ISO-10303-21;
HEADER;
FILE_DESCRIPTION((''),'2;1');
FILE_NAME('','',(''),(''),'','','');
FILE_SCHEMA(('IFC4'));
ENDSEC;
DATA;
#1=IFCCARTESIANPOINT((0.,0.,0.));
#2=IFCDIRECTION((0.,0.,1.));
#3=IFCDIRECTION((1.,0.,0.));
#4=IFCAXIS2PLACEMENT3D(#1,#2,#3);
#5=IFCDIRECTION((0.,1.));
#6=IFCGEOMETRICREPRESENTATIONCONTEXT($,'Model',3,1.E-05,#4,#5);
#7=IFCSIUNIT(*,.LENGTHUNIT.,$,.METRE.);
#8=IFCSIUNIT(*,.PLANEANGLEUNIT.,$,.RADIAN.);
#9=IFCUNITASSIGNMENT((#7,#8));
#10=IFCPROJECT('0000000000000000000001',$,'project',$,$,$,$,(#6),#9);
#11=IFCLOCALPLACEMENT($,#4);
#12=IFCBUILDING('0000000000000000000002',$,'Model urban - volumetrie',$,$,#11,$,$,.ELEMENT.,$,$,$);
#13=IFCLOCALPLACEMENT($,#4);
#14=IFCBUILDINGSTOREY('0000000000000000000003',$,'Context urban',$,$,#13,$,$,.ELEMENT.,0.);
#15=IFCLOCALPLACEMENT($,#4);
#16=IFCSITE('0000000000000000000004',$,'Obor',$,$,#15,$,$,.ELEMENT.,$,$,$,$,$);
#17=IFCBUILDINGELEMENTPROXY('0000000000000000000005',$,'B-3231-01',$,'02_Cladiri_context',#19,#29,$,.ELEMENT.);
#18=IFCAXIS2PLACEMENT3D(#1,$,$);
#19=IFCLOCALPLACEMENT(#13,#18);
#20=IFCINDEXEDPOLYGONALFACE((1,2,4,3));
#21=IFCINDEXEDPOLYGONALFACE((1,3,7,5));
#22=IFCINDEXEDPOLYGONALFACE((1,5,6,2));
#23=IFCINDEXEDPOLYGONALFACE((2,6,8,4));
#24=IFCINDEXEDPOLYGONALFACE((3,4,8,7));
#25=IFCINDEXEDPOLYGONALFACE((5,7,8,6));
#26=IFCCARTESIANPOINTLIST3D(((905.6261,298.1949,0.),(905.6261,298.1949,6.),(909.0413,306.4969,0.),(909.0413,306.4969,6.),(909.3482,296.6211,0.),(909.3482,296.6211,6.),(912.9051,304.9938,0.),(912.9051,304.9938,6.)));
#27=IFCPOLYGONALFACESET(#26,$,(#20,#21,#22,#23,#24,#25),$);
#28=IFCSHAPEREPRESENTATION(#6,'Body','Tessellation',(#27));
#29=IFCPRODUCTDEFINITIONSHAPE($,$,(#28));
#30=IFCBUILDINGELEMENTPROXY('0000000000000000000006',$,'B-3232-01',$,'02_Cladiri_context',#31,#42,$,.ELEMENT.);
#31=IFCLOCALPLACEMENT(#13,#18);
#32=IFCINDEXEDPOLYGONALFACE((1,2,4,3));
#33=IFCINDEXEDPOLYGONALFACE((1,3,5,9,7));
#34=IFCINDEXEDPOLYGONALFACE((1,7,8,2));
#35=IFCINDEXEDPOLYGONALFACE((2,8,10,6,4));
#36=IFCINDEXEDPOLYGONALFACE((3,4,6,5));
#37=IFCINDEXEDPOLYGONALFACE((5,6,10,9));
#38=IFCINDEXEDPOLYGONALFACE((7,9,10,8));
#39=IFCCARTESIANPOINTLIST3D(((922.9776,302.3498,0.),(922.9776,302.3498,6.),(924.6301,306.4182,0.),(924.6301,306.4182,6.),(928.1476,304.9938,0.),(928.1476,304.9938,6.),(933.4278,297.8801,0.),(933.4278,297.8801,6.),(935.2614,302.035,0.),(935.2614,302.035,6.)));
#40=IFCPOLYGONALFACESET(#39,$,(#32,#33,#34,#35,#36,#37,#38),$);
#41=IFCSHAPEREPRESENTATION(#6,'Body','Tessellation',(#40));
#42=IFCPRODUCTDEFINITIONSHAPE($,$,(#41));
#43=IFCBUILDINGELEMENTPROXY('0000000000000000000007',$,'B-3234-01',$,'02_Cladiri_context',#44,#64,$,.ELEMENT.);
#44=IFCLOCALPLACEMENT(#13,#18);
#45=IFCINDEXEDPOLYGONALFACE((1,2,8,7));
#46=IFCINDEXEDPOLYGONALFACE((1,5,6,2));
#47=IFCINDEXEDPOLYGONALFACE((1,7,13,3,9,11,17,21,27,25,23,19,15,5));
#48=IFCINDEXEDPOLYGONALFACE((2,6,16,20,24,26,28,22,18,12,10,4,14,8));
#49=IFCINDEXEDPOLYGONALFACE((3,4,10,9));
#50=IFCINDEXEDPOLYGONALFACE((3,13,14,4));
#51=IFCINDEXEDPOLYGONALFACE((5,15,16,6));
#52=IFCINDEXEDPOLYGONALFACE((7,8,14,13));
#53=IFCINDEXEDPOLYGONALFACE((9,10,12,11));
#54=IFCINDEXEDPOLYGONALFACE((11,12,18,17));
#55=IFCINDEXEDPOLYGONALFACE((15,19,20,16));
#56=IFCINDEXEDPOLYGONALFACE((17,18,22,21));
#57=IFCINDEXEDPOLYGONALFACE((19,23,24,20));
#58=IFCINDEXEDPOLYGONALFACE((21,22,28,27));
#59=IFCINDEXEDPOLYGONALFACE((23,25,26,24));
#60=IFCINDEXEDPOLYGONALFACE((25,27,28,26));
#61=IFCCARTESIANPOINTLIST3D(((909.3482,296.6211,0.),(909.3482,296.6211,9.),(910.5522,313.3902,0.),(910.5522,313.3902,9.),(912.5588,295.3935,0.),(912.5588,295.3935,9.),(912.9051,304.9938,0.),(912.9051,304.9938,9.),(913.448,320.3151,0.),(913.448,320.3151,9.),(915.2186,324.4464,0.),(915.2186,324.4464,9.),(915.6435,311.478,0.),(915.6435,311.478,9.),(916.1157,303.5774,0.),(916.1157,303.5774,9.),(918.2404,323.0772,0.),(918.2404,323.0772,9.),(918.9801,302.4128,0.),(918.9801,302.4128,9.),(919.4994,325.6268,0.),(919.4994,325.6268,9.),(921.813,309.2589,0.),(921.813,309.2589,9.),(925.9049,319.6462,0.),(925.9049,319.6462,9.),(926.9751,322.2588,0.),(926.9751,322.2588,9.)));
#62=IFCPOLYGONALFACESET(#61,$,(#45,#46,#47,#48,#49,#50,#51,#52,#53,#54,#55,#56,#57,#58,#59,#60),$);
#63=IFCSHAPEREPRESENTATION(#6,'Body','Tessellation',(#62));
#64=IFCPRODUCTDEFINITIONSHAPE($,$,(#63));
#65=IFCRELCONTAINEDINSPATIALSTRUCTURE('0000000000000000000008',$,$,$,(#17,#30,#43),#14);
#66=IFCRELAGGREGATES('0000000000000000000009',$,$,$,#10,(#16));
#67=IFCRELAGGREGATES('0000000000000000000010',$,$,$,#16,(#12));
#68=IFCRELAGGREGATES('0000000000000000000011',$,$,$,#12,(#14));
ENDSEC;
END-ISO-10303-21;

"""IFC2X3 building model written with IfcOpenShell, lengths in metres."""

from ifc_helpers import new_model, si_unit, direction, origin_with_axes, place, context, project, spatial, polyline, outline, extrude, element, save


model = new_model("IFC2X3")

# Units and contexts
model_context = context("Model", 3, precision=1e-05, world=origin_with_axes(), true_north=direction((0.0, 1.0)))
ifc_project = project(units=[si_unit("LENGTHUNIT", "METRE"), si_unit("PLANEANGLEUNIT", "RADIAN")], contexts=[model_context])

# Site, building, storey
site_placement = place(None, origin_with_axes())
site = spatial("IfcSite", under=ifc_project, at=site_placement, Name="Obor", CompositionType="ELEMENT")
building_placement = place(None, origin_with_axes())
building = spatial("IfcBuilding", under=site, at=building_placement, Name="Model urban - volumetrie", CompositionType="ELEMENT")
storey_placement = place(None, origin_with_axes())
storey = spatial("IfcBuildingStorey", under=building, at=storey_placement, Name="Context urban", CompositionType="ELEMENT", Elevation=0.0)

# Building element proxies
proxy_1_placement = place(None, origin_with_axes())
element("IfcBuildingElementProxy", 1, at=proxy_1_placement, inside=storey, Name="B-3231-01", ObjectType="02_Cladiri_context", CompositionType="ELEMENT", context=model_context, shape_type="SweptSolid", body=[
    extrude(outline(polyline([(905.6261, 298.1949), (909.3482, 296.6211), (912.9051, 304.9938), (909.0413, 306.4969), (905.6261, 298.1949)])), origin_with_axes(), (0.0, 0.0, 1.0), 6.0),
])
proxy_2_placement = place(None, origin_with_axes())
element("IfcBuildingElementProxy", 2, at=proxy_2_placement, inside=storey, Name="B-3232-01", ObjectType="02_Cladiri_context", CompositionType="ELEMENT", context=model_context, shape_type="SweptSolid", body=[
    extrude(outline(polyline([(928.1476, 304.9938), (924.6301, 306.4182), (922.9776, 302.3498), (933.4278, 297.8801), (935.2614, 302.035), (928.1476, 304.9938)])), origin_with_axes(), (0.0, 0.0, 1.0), 6.0),
])
proxy_3_placement = place(None, origin_with_axes())
element("IfcBuildingElementProxy", 3, at=proxy_3_placement, inside=storey, Name="B-3234-01", ObjectType="02_Cladiri_context", CompositionType="ELEMENT", context=model_context, shape_type="SweptSolid", body=[
    extrude(outline(polyline([(925.9049, 319.6462), (926.9751, 322.2588), (919.4994, 325.6268), (918.2404, 323.0772), (915.2186, 324.4464), (913.448, 320.3151), (910.5522, 313.3902), (915.6435, 311.478), (912.9051, 304.9938), (909.3482, 296.6211), (912.5588, 295.3935), (916.1157, 303.5774), (918.9801, 302.4128), (921.813, 309.2589), (925.9049, 319.6462)])), origin_with_axes(), (0.0, 0.0, 1.0), 9.0),
])

save(model, "model.ifc")
